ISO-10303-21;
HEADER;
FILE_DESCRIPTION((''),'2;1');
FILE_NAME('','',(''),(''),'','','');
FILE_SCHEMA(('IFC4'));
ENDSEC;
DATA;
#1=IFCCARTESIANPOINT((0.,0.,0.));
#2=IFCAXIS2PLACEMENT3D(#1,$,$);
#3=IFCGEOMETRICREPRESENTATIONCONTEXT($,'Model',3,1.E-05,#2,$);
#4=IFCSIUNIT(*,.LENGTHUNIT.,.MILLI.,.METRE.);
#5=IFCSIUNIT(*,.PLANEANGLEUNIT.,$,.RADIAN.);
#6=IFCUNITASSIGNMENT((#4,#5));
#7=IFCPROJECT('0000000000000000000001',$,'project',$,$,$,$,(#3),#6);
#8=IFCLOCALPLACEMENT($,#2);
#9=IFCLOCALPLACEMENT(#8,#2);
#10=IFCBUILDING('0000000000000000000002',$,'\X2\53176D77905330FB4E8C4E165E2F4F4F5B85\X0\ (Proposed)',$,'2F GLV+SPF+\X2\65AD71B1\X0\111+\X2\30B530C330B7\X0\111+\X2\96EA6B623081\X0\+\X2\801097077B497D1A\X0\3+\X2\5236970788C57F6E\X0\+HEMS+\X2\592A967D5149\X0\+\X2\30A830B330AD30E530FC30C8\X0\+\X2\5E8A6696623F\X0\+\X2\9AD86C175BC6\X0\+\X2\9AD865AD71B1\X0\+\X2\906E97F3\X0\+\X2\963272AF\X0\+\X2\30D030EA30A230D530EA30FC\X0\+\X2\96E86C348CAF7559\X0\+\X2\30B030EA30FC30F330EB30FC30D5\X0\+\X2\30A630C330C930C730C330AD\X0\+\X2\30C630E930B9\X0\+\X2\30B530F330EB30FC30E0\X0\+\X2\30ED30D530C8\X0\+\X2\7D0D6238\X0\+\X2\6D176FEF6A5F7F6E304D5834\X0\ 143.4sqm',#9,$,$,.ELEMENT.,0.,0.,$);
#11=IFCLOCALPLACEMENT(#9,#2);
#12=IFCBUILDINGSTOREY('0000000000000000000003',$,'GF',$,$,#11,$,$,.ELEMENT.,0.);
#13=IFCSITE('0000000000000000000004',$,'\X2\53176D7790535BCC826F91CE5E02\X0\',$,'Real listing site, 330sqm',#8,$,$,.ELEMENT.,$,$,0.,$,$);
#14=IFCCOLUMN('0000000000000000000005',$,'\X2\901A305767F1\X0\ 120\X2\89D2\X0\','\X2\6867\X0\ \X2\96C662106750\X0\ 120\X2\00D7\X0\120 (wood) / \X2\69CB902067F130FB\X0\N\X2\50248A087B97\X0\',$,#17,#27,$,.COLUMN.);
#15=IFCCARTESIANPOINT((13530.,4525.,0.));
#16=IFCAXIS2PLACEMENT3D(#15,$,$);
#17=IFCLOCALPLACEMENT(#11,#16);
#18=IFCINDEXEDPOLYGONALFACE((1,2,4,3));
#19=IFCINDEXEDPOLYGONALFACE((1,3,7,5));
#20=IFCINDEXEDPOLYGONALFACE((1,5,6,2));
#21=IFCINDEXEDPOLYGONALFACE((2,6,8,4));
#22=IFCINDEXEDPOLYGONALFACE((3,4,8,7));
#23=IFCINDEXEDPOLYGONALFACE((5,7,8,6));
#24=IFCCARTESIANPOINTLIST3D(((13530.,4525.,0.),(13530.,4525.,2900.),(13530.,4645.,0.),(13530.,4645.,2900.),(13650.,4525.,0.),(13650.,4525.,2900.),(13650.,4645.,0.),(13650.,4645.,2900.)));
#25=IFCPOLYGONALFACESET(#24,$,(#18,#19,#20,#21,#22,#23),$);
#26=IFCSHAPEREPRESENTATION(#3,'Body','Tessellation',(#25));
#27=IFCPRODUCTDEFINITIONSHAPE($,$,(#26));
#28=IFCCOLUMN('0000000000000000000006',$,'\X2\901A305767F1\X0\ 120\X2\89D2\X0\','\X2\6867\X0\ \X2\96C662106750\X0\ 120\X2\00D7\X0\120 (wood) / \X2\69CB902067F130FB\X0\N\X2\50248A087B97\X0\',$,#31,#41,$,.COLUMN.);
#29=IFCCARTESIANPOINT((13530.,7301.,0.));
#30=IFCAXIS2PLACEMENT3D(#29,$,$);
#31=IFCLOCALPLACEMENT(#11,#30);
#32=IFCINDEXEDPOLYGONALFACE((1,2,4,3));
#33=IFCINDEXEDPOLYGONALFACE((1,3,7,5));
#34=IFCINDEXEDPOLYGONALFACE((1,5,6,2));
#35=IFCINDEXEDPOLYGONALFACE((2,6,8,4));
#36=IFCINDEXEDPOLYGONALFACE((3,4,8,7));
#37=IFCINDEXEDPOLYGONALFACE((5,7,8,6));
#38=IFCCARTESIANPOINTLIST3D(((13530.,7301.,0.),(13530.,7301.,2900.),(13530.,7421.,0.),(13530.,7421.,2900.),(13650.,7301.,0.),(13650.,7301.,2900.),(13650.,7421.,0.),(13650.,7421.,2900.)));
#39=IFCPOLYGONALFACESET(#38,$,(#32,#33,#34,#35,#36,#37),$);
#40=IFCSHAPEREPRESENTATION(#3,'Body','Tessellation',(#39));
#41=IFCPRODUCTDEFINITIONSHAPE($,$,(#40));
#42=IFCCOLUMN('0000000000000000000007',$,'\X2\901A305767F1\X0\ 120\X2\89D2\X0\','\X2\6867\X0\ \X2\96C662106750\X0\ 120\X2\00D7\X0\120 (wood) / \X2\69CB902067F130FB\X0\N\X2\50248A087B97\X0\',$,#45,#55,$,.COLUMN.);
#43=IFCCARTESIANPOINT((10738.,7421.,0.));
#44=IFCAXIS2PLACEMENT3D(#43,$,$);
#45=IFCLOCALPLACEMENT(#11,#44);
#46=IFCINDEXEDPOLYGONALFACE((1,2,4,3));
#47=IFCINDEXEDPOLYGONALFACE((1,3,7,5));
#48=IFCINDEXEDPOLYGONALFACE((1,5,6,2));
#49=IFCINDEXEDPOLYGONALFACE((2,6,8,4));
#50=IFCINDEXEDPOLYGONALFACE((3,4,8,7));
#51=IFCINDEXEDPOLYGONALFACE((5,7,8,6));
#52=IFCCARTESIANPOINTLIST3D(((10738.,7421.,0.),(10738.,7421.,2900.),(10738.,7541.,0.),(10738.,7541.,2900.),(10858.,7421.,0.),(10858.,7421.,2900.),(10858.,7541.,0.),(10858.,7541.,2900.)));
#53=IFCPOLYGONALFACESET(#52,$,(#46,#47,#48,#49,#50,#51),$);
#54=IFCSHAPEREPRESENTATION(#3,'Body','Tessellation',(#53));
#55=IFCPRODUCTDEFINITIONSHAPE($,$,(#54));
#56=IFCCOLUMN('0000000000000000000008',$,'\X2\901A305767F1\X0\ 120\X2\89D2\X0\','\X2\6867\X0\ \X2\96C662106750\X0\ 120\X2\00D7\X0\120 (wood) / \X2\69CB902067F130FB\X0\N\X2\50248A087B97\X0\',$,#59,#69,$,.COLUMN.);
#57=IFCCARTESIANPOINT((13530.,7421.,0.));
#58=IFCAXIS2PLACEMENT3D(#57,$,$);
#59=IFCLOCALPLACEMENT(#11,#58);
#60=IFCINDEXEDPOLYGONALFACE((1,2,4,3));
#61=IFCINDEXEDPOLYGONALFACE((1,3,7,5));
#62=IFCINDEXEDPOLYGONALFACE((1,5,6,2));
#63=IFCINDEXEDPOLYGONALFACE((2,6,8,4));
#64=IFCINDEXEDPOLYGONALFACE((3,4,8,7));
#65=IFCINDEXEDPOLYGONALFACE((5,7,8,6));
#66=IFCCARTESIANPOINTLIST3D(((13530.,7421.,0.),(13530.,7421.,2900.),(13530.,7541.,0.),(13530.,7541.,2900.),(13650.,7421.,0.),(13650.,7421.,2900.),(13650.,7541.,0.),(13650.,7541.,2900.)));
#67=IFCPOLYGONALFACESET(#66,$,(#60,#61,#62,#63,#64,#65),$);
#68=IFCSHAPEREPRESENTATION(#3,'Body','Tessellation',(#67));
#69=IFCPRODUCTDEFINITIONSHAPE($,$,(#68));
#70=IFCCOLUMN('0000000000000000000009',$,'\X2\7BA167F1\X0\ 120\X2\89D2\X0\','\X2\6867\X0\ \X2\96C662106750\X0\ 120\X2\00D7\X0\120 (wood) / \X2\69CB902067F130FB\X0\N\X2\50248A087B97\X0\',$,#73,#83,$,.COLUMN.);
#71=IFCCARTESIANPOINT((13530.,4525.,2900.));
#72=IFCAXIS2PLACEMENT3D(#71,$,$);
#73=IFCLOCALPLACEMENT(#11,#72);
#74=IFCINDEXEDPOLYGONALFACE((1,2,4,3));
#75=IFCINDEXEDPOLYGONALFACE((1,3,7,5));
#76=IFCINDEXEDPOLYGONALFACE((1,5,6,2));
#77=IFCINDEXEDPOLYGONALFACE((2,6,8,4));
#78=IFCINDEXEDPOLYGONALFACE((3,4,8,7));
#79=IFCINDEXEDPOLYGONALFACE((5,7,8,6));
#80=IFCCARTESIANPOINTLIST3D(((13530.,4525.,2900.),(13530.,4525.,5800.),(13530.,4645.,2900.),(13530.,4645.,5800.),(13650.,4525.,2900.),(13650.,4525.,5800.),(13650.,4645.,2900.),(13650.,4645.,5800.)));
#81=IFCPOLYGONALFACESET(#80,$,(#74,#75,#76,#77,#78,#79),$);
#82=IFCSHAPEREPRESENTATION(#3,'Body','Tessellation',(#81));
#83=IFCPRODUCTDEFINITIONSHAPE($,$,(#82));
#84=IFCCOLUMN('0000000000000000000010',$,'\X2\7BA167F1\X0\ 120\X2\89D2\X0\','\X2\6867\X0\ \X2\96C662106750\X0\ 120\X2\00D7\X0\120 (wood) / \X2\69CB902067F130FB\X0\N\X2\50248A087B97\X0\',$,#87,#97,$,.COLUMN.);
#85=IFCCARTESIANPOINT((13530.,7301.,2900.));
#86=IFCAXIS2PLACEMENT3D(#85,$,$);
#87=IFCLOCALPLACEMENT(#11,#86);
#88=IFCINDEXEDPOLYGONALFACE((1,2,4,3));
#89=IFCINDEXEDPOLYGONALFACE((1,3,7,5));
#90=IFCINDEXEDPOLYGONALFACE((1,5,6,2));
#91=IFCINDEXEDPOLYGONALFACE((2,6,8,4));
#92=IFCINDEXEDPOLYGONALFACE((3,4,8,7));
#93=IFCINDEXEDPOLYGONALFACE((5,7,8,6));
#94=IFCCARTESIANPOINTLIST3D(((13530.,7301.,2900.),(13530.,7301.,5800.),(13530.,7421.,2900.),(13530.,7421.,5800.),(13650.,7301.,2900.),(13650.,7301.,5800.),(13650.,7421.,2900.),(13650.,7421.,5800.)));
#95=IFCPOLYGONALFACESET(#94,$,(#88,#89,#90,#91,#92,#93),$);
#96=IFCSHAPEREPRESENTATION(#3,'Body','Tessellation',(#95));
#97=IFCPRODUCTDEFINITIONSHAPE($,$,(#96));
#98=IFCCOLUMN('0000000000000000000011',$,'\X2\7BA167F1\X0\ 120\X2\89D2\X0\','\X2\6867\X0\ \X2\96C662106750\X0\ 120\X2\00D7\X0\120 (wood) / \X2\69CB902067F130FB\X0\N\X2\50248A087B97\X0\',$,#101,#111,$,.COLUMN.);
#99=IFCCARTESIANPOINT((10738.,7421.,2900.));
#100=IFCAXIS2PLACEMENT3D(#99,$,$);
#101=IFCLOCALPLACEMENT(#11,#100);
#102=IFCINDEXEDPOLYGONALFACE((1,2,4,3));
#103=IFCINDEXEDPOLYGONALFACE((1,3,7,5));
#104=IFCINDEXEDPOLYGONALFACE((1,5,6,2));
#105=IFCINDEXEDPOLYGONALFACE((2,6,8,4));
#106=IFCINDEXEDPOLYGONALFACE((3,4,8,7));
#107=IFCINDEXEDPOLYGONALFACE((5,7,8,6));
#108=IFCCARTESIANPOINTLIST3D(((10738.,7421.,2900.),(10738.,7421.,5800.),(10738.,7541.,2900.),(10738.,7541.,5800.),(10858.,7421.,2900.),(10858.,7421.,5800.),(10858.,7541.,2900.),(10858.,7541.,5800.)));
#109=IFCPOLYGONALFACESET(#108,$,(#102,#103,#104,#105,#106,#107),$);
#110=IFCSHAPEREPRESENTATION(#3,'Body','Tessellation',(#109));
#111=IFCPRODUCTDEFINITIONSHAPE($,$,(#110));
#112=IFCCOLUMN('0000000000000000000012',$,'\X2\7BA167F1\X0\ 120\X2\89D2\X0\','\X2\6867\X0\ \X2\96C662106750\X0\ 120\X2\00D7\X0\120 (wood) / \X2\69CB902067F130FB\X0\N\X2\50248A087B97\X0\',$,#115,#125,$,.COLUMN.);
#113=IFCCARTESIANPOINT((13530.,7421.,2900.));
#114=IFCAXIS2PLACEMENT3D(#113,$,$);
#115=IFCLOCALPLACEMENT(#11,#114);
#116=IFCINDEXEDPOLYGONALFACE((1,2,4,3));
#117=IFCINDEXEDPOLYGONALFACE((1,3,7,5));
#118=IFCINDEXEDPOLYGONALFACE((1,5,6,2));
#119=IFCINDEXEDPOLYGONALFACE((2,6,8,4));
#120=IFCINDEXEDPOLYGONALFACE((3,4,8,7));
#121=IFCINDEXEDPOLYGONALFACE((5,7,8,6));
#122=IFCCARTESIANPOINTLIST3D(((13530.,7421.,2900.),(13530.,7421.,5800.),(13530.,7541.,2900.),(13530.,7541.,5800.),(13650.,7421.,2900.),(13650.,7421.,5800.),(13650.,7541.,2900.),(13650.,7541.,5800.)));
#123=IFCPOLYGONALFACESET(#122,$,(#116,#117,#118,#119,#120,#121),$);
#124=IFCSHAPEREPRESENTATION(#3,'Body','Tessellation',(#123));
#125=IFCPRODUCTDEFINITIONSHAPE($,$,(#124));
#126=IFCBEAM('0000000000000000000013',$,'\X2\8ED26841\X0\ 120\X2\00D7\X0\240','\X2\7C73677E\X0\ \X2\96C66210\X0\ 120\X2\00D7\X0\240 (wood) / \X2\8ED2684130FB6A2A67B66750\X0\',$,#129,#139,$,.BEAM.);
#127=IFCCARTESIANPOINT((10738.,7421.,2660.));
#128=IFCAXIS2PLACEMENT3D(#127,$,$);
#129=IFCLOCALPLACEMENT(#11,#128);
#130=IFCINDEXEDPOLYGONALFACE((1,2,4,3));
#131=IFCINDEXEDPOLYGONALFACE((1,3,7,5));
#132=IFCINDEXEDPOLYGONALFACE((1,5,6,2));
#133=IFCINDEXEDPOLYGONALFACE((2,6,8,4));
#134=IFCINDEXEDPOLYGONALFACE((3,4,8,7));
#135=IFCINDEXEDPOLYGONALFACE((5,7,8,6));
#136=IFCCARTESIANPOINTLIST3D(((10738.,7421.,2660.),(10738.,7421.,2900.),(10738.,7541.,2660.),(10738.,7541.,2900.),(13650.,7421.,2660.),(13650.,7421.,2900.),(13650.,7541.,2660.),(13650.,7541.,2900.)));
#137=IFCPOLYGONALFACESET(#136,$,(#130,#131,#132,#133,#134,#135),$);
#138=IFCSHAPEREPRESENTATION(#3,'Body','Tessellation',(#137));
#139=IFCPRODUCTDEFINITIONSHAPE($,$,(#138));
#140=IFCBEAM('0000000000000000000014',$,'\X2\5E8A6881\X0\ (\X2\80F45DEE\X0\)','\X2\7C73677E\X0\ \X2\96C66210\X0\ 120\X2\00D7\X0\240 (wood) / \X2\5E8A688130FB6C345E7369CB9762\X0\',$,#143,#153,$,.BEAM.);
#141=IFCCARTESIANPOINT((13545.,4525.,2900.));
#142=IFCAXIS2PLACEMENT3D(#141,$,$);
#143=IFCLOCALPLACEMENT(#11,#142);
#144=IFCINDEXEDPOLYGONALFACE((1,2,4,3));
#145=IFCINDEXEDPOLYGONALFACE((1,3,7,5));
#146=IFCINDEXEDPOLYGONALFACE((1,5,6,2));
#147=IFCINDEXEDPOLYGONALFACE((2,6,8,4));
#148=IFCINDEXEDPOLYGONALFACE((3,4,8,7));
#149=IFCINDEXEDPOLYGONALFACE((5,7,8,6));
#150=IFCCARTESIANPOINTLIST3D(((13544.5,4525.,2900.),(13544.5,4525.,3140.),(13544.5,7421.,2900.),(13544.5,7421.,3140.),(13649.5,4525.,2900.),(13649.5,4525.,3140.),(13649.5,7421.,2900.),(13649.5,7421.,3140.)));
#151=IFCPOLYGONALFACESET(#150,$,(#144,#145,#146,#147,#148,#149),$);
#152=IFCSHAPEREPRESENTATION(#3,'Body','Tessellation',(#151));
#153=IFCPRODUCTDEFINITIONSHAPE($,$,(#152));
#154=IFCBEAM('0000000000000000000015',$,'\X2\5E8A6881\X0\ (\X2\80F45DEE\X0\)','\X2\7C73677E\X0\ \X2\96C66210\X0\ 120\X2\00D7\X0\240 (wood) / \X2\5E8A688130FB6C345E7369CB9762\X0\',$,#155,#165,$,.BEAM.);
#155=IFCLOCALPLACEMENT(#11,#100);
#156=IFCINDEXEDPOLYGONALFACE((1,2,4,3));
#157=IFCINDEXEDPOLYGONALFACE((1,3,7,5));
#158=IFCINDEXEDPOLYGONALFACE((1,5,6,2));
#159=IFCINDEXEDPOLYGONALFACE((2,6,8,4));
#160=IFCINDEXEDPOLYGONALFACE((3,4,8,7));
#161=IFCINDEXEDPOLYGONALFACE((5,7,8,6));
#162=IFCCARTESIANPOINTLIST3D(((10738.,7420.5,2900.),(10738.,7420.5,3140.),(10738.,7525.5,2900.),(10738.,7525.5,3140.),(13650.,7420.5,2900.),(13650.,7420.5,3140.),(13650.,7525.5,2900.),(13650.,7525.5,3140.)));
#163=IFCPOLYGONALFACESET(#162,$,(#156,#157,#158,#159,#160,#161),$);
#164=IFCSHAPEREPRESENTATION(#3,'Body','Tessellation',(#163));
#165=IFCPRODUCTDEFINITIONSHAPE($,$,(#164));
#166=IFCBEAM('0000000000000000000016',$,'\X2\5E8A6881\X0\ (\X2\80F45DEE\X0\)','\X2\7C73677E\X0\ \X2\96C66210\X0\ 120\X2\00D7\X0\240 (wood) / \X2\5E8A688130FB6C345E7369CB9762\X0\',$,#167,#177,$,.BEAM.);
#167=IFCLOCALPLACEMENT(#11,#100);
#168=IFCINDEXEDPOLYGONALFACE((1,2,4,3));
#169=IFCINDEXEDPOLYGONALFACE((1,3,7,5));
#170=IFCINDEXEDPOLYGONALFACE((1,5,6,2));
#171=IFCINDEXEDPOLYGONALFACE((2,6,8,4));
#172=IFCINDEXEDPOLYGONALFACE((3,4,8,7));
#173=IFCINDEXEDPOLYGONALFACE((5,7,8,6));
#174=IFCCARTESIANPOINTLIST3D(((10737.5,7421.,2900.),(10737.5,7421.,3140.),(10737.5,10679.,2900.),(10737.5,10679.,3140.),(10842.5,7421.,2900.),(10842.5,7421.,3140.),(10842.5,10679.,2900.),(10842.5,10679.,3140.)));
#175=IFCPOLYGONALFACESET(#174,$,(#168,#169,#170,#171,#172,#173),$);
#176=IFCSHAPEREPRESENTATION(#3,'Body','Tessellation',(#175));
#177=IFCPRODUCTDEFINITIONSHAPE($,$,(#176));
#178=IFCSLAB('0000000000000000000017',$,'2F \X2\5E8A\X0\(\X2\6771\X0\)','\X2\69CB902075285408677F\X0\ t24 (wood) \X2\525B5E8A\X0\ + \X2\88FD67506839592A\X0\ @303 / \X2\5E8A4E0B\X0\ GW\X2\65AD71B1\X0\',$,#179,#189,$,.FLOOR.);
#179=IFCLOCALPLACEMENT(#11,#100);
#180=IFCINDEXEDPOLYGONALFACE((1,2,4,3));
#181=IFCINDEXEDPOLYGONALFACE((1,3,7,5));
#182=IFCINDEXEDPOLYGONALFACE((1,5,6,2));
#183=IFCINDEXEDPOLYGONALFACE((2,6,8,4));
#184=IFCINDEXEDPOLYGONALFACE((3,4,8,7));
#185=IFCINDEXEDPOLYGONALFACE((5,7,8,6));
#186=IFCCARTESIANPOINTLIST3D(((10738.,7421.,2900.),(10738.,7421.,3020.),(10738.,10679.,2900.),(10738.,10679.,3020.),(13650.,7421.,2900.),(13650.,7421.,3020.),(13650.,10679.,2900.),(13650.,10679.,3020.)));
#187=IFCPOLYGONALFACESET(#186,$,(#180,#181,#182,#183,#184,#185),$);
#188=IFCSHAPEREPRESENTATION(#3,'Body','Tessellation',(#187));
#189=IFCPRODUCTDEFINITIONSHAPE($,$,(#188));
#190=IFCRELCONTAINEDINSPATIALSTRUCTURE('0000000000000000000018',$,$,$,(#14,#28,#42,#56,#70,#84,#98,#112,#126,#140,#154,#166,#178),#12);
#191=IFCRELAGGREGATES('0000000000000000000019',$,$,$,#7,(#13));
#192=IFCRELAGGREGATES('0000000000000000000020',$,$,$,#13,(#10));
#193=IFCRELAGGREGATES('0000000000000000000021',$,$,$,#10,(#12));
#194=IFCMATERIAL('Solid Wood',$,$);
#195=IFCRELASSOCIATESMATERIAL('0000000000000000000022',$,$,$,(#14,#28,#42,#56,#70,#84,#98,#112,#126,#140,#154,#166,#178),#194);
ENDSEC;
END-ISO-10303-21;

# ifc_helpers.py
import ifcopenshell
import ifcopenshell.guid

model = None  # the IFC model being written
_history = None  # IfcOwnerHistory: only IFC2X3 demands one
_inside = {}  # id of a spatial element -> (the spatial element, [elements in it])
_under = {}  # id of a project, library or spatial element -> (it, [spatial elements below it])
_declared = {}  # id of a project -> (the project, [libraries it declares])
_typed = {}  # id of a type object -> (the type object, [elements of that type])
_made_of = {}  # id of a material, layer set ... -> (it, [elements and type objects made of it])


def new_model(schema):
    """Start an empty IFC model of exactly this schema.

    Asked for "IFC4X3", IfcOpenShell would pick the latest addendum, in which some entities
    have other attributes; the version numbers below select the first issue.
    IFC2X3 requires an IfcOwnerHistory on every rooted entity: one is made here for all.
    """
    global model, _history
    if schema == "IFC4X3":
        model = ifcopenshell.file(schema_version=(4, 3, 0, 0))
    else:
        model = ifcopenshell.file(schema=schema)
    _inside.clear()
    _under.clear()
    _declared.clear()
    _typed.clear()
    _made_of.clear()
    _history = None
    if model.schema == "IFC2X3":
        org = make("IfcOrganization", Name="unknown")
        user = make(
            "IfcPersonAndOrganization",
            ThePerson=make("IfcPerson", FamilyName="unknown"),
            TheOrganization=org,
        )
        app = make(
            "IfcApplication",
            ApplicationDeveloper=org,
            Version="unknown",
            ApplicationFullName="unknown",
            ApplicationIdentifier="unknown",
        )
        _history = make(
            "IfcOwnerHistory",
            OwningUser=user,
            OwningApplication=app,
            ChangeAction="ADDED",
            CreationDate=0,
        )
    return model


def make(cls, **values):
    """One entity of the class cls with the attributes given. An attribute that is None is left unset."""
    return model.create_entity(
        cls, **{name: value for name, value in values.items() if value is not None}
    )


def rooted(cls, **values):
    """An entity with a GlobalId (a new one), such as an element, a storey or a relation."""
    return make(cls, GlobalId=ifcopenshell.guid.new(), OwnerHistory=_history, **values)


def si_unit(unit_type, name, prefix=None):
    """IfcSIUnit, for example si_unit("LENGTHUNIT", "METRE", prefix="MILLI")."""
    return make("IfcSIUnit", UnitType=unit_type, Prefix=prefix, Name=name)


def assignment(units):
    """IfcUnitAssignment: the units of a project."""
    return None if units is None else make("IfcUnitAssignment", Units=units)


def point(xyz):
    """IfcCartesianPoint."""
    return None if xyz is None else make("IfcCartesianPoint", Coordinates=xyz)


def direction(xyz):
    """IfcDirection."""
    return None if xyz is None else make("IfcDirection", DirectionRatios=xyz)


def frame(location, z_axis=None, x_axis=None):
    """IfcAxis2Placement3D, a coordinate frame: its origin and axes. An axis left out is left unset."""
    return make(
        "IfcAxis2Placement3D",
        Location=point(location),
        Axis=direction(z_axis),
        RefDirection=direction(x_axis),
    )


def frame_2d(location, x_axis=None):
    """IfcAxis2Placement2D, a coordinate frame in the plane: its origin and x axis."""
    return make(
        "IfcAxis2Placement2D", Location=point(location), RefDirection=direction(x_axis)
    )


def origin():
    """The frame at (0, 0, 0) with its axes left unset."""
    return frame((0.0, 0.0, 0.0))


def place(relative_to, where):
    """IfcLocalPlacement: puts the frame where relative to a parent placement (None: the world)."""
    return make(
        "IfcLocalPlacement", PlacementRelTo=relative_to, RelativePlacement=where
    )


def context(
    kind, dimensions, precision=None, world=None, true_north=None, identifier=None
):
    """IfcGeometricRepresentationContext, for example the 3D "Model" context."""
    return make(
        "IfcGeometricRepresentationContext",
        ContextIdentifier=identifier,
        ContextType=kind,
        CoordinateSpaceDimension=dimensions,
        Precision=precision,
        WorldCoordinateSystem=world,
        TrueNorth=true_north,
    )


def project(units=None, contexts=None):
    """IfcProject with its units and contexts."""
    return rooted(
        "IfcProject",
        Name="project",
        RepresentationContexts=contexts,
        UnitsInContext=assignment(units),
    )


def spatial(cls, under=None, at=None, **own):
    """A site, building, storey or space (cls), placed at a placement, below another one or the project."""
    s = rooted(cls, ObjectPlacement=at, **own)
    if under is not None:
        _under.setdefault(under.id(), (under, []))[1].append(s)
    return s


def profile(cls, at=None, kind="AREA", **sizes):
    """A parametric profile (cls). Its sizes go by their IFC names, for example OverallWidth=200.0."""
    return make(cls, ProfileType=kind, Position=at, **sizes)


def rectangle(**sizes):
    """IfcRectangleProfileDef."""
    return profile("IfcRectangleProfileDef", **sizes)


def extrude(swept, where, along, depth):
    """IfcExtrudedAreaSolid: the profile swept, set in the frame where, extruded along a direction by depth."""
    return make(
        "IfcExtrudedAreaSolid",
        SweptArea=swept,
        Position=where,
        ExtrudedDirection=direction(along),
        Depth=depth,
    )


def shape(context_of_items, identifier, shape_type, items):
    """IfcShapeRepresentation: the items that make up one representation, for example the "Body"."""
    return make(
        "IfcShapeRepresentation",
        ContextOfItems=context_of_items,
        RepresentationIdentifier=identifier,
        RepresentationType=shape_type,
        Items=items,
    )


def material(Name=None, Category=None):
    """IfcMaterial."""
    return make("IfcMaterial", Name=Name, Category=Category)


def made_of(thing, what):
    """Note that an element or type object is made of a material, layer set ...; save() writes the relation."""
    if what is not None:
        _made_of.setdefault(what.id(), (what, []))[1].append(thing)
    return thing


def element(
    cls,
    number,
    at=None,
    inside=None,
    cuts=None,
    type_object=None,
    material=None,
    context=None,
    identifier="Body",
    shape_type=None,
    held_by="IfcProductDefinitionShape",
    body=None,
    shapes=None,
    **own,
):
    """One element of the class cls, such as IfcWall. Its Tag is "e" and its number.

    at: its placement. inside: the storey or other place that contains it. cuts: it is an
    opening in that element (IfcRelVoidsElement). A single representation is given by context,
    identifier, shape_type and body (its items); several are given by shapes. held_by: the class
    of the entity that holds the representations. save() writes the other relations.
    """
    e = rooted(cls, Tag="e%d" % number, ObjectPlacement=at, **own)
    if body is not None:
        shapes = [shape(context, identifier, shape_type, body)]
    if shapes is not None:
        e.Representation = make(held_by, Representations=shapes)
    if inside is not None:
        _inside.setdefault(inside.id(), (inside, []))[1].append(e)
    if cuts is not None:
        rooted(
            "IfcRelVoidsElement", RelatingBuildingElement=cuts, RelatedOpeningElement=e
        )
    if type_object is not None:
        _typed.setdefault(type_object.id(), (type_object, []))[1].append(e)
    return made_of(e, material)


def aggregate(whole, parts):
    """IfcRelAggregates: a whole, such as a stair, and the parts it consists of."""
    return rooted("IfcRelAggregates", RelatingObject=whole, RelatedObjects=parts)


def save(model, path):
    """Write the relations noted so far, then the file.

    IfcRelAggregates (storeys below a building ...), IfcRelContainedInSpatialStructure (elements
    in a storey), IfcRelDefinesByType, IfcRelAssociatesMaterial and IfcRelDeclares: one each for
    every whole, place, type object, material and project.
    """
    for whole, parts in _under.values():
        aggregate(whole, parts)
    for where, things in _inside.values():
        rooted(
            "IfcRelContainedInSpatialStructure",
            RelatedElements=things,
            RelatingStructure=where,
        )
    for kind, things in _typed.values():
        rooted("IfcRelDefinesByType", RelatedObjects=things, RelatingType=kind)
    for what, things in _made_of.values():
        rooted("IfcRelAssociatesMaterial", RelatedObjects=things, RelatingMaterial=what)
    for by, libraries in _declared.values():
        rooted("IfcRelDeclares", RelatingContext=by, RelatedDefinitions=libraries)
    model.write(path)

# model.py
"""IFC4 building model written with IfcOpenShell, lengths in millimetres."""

from ifc_helpers import new_model, si_unit, frame, frame_2d, origin, place, context, project, spatial, rectangle, extrude, material, element, save


model = new_model("IFC4")

# Units and contexts
model_context = context("Model", 3, precision=1e-05, world=origin())
ifc_project = project(units=[si_unit("LENGTHUNIT", "METRE", prefix="MILLI"), si_unit("PLANEANGLEUNIT", "RADIAN")], contexts=[model_context])

# Site, building, storey
site_placement = place(None, origin())
site = spatial("IfcSite", under=ifc_project, at=site_placement, Name="北海道富良野市", ObjectType="Real listing site, 330sqm", CompositionType="ELEMENT", RefElevation=0.0)
building_placement = place(site_placement, origin())
building = spatial("IfcBuilding", under=site, at=building_placement, Name="北海道・二世帯住宅 (Proposed)", ObjectType="2F GLV+SPF+断熱111+サッシ111+雪止め+耐震等級3+制震装置+HEMS+太陽光+エコキュート+床暖房+高気密+高断熱+遮音+防犯+バリアフリー+雨水貯留+グリーンルーフ+ウッドデッキ+テラス+サンルーム+ロフト+納戸+洗濯機置き場 143.4sqm", CompositionType="ELEMENT", ElevationOfRefHeight=0.0, ElevationOfTerrain=0.0)
storey_placement = place(building_placement, origin())
storey = spatial("IfcBuildingStorey", under=building, at=storey_placement, Name="GF", CompositionType="ELEMENT", Elevation=0.0)

# Columns
ifc_material_1 = material(Name="Solid Wood")
column_1_placement = place(storey_placement, frame((13530.0, 4525.0, 0.0)))
element("IfcColumn", 1, at=column_1_placement, inside=storey, material=ifc_material_1, Name="通し柱 120角", Description="桧 集成材 120×120 (wood) / 構造柱・N値計算", PredefinedType="COLUMN", context=model_context, shape_type="SweptSolid", body=[
    extrude(rectangle(XDim=120.0, YDim=120.0, at=frame_2d((60.0, 60.0))), frame((13530.0, 4525.0, 0.0)), (0.0, 0.0, 1.0), 2900.0),
])
column_2_placement = place(storey_placement, frame((13530.0, 7301.0, 0.0)))
element("IfcColumn", 2, at=column_2_placement, inside=storey, material=ifc_material_1, Name="通し柱 120角", Description="桧 集成材 120×120 (wood) / 構造柱・N値計算", PredefinedType="COLUMN", context=model_context, shape_type="SweptSolid", body=[
    extrude(rectangle(XDim=120.0, YDim=120.0, at=frame_2d((60.0, 60.0))), frame((13530.0, 7301.0, 0.0)), (0.0, 0.0, 1.0), 2900.0),
])
column_3_placement = place(storey_placement, frame((10738.0, 7421.0, 0.0)))
element("IfcColumn", 3, at=column_3_placement, inside=storey, material=ifc_material_1, Name="通し柱 120角", Description="桧 集成材 120×120 (wood) / 構造柱・N値計算", PredefinedType="COLUMN", context=model_context, shape_type="SweptSolid", body=[
    extrude(rectangle(XDim=120.0, YDim=120.0, at=frame_2d((60.0, 60.0))), frame((10738.0, 7421.0, 0.0)), (0.0, 0.0, 1.0), 2900.0),
])
column_4_placement = place(storey_placement, frame((13530.0, 7421.0, 0.0)))
element("IfcColumn", 4, at=column_4_placement, inside=storey, material=ifc_material_1, Name="通し柱 120角", Description="桧 集成材 120×120 (wood) / 構造柱・N値計算", PredefinedType="COLUMN", context=model_context, shape_type="SweptSolid", body=[
    extrude(rectangle(XDim=120.0, YDim=120.0, at=frame_2d((60.0, 60.0))), frame((13530.0, 7421.0, 0.0)), (0.0, 0.0, 1.0), 2900.0),
])
column_5_placement = place(storey_placement, frame((13530.0, 4525.0, 2900.0)))
element("IfcColumn", 5, at=column_5_placement, inside=storey, material=ifc_material_1, Name="管柱 120角", Description="桧 集成材 120×120 (wood) / 構造柱・N値計算", PredefinedType="COLUMN", context=model_context, shape_type="SweptSolid", body=[
    extrude(rectangle(XDim=120.0, YDim=120.0, at=frame_2d((60.0, 60.0))), frame((13530.0, 4525.0, 2900.0)), (0.0, 0.0, 1.0), 2900.0),
])
column_6_placement = place(storey_placement, frame((13530.0, 7301.0, 2900.0)))
element("IfcColumn", 6, at=column_6_placement, inside=storey, material=ifc_material_1, Name="管柱 120角", Description="桧 集成材 120×120 (wood) / 構造柱・N値計算", PredefinedType="COLUMN", context=model_context, shape_type="SweptSolid", body=[
    extrude(rectangle(XDim=120.0, YDim=120.0, at=frame_2d((60.0, 60.0))), frame((13530.0, 7301.0, 2900.0)), (0.0, 0.0, 1.0), 2900.0),
])
column_7_placement = place(storey_placement, frame((10738.0, 7421.0, 2900.0)))
element("IfcColumn", 7, at=column_7_placement, inside=storey, material=ifc_material_1, Name="管柱 120角", Description="桧 集成材 120×120 (wood) / 構造柱・N値計算", PredefinedType="COLUMN", context=model_context, shape_type="SweptSolid", body=[
    extrude(rectangle(XDim=120.0, YDim=120.0, at=frame_2d((60.0, 60.0))), frame((10738.0, 7421.0, 2900.0)), (0.0, 0.0, 1.0), 2900.0),
])
column_8_placement = place(storey_placement, frame((13530.0, 7421.0, 2900.0)))
element("IfcColumn", 8, at=column_8_placement, inside=storey, material=ifc_material_1, Name="管柱 120角", Description="桧 集成材 120×120 (wood) / 構造柱・N値計算", PredefinedType="COLUMN", context=model_context, shape_type="SweptSolid", body=[
    extrude(rectangle(XDim=120.0, YDim=120.0, at=frame_2d((60.0, 60.0))), frame((13530.0, 7421.0, 2900.0)), (0.0, 0.0, 1.0), 2900.0),
])

# Beams
beam_1_placement = place(storey_placement, frame((10738.0, 7421.0, 2660.0)))
element("IfcBeam", 9, at=beam_1_placement, inside=storey, material=ifc_material_1, Name="軒桁 120×240", Description="米松 集成 120×240 (wood) / 軒桁・横架材", PredefinedType="BEAM", context=model_context, shape_type="SweptSolid", body=[
    extrude(rectangle(XDim=2912.0, YDim=120.0, at=frame_2d((1456.0, 60.0))), frame((10738.0, 7421.0, 2660.0)), (0.0, 0.0, 1.0), 240.0),
])
beam_2_placement = place(storey_placement, frame((13545.0, 4525.0, 2900.0)))
element("IfcBeam", 10, at=beam_2_placement, inside=storey, material=ifc_material_1, Name="床梁 (胴差)", Description="米松 集成 120×240 (wood) / 床梁・水平構面", PredefinedType="BEAM", context=model_context, shape_type="SweptSolid", body=[
    extrude(rectangle(XDim=105.0, YDim=2896.0, at=frame_2d((52.0, 1448.0))), frame((13545.0, 4525.0, 2900.0)), (0.0, 0.0, 1.0), 240.0),
])
beam_3_placement = place(storey_placement, frame((10738.0, 7421.0, 2900.0)))
element("IfcBeam", 11, at=beam_3_placement, inside=storey, material=ifc_material_1, Name="床梁 (胴差)", Description="米松 集成 120×240 (wood) / 床梁・水平構面", PredefinedType="BEAM", context=model_context, shape_type="SweptSolid", body=[
    extrude(rectangle(XDim=2912.0, YDim=105.0, at=frame_2d((1456.0, 52.0))), frame((10738.0, 7421.0, 2900.0)), (0.0, 0.0, 1.0), 240.0),
])
beam_4_placement = place(storey_placement, frame((10738.0, 7421.0, 2900.0)))
element("IfcBeam", 12, at=beam_4_placement, inside=storey, material=ifc_material_1, Name="床梁 (胴差)", Description="米松 集成 120×240 (wood) / 床梁・水平構面", PredefinedType="BEAM", context=model_context, shape_type="SweptSolid", body=[
    extrude(rectangle(XDim=105.0, YDim=3258.0, at=frame_2d((52.0, 1629.0))), frame((10738.0, 7421.0, 2900.0)), (0.0, 0.0, 1.0), 240.0),
])

# Slab
slab_placement = place(storey_placement, frame((10738.0, 7421.0, 2900.0)))
element("IfcSlab", 13, at=slab_placement, inside=storey, material=ifc_material_1, Name="2F 床(東)", Description="構造用合板 t24 (wood) 剛床 + 製材根太 @303 / 床下 GW断熱", PredefinedType="FLOOR", context=model_context, shape_type="SweptSolid", body=[
    extrude(rectangle(XDim=2912.0, YDim=3258.0, at=frame_2d((1456.0, 1629.0))), frame((10738.0, 7421.0, 2900.0)), (0.0, 0.0, 1.0), 120.0),
])

save(model, "model.ifc")
